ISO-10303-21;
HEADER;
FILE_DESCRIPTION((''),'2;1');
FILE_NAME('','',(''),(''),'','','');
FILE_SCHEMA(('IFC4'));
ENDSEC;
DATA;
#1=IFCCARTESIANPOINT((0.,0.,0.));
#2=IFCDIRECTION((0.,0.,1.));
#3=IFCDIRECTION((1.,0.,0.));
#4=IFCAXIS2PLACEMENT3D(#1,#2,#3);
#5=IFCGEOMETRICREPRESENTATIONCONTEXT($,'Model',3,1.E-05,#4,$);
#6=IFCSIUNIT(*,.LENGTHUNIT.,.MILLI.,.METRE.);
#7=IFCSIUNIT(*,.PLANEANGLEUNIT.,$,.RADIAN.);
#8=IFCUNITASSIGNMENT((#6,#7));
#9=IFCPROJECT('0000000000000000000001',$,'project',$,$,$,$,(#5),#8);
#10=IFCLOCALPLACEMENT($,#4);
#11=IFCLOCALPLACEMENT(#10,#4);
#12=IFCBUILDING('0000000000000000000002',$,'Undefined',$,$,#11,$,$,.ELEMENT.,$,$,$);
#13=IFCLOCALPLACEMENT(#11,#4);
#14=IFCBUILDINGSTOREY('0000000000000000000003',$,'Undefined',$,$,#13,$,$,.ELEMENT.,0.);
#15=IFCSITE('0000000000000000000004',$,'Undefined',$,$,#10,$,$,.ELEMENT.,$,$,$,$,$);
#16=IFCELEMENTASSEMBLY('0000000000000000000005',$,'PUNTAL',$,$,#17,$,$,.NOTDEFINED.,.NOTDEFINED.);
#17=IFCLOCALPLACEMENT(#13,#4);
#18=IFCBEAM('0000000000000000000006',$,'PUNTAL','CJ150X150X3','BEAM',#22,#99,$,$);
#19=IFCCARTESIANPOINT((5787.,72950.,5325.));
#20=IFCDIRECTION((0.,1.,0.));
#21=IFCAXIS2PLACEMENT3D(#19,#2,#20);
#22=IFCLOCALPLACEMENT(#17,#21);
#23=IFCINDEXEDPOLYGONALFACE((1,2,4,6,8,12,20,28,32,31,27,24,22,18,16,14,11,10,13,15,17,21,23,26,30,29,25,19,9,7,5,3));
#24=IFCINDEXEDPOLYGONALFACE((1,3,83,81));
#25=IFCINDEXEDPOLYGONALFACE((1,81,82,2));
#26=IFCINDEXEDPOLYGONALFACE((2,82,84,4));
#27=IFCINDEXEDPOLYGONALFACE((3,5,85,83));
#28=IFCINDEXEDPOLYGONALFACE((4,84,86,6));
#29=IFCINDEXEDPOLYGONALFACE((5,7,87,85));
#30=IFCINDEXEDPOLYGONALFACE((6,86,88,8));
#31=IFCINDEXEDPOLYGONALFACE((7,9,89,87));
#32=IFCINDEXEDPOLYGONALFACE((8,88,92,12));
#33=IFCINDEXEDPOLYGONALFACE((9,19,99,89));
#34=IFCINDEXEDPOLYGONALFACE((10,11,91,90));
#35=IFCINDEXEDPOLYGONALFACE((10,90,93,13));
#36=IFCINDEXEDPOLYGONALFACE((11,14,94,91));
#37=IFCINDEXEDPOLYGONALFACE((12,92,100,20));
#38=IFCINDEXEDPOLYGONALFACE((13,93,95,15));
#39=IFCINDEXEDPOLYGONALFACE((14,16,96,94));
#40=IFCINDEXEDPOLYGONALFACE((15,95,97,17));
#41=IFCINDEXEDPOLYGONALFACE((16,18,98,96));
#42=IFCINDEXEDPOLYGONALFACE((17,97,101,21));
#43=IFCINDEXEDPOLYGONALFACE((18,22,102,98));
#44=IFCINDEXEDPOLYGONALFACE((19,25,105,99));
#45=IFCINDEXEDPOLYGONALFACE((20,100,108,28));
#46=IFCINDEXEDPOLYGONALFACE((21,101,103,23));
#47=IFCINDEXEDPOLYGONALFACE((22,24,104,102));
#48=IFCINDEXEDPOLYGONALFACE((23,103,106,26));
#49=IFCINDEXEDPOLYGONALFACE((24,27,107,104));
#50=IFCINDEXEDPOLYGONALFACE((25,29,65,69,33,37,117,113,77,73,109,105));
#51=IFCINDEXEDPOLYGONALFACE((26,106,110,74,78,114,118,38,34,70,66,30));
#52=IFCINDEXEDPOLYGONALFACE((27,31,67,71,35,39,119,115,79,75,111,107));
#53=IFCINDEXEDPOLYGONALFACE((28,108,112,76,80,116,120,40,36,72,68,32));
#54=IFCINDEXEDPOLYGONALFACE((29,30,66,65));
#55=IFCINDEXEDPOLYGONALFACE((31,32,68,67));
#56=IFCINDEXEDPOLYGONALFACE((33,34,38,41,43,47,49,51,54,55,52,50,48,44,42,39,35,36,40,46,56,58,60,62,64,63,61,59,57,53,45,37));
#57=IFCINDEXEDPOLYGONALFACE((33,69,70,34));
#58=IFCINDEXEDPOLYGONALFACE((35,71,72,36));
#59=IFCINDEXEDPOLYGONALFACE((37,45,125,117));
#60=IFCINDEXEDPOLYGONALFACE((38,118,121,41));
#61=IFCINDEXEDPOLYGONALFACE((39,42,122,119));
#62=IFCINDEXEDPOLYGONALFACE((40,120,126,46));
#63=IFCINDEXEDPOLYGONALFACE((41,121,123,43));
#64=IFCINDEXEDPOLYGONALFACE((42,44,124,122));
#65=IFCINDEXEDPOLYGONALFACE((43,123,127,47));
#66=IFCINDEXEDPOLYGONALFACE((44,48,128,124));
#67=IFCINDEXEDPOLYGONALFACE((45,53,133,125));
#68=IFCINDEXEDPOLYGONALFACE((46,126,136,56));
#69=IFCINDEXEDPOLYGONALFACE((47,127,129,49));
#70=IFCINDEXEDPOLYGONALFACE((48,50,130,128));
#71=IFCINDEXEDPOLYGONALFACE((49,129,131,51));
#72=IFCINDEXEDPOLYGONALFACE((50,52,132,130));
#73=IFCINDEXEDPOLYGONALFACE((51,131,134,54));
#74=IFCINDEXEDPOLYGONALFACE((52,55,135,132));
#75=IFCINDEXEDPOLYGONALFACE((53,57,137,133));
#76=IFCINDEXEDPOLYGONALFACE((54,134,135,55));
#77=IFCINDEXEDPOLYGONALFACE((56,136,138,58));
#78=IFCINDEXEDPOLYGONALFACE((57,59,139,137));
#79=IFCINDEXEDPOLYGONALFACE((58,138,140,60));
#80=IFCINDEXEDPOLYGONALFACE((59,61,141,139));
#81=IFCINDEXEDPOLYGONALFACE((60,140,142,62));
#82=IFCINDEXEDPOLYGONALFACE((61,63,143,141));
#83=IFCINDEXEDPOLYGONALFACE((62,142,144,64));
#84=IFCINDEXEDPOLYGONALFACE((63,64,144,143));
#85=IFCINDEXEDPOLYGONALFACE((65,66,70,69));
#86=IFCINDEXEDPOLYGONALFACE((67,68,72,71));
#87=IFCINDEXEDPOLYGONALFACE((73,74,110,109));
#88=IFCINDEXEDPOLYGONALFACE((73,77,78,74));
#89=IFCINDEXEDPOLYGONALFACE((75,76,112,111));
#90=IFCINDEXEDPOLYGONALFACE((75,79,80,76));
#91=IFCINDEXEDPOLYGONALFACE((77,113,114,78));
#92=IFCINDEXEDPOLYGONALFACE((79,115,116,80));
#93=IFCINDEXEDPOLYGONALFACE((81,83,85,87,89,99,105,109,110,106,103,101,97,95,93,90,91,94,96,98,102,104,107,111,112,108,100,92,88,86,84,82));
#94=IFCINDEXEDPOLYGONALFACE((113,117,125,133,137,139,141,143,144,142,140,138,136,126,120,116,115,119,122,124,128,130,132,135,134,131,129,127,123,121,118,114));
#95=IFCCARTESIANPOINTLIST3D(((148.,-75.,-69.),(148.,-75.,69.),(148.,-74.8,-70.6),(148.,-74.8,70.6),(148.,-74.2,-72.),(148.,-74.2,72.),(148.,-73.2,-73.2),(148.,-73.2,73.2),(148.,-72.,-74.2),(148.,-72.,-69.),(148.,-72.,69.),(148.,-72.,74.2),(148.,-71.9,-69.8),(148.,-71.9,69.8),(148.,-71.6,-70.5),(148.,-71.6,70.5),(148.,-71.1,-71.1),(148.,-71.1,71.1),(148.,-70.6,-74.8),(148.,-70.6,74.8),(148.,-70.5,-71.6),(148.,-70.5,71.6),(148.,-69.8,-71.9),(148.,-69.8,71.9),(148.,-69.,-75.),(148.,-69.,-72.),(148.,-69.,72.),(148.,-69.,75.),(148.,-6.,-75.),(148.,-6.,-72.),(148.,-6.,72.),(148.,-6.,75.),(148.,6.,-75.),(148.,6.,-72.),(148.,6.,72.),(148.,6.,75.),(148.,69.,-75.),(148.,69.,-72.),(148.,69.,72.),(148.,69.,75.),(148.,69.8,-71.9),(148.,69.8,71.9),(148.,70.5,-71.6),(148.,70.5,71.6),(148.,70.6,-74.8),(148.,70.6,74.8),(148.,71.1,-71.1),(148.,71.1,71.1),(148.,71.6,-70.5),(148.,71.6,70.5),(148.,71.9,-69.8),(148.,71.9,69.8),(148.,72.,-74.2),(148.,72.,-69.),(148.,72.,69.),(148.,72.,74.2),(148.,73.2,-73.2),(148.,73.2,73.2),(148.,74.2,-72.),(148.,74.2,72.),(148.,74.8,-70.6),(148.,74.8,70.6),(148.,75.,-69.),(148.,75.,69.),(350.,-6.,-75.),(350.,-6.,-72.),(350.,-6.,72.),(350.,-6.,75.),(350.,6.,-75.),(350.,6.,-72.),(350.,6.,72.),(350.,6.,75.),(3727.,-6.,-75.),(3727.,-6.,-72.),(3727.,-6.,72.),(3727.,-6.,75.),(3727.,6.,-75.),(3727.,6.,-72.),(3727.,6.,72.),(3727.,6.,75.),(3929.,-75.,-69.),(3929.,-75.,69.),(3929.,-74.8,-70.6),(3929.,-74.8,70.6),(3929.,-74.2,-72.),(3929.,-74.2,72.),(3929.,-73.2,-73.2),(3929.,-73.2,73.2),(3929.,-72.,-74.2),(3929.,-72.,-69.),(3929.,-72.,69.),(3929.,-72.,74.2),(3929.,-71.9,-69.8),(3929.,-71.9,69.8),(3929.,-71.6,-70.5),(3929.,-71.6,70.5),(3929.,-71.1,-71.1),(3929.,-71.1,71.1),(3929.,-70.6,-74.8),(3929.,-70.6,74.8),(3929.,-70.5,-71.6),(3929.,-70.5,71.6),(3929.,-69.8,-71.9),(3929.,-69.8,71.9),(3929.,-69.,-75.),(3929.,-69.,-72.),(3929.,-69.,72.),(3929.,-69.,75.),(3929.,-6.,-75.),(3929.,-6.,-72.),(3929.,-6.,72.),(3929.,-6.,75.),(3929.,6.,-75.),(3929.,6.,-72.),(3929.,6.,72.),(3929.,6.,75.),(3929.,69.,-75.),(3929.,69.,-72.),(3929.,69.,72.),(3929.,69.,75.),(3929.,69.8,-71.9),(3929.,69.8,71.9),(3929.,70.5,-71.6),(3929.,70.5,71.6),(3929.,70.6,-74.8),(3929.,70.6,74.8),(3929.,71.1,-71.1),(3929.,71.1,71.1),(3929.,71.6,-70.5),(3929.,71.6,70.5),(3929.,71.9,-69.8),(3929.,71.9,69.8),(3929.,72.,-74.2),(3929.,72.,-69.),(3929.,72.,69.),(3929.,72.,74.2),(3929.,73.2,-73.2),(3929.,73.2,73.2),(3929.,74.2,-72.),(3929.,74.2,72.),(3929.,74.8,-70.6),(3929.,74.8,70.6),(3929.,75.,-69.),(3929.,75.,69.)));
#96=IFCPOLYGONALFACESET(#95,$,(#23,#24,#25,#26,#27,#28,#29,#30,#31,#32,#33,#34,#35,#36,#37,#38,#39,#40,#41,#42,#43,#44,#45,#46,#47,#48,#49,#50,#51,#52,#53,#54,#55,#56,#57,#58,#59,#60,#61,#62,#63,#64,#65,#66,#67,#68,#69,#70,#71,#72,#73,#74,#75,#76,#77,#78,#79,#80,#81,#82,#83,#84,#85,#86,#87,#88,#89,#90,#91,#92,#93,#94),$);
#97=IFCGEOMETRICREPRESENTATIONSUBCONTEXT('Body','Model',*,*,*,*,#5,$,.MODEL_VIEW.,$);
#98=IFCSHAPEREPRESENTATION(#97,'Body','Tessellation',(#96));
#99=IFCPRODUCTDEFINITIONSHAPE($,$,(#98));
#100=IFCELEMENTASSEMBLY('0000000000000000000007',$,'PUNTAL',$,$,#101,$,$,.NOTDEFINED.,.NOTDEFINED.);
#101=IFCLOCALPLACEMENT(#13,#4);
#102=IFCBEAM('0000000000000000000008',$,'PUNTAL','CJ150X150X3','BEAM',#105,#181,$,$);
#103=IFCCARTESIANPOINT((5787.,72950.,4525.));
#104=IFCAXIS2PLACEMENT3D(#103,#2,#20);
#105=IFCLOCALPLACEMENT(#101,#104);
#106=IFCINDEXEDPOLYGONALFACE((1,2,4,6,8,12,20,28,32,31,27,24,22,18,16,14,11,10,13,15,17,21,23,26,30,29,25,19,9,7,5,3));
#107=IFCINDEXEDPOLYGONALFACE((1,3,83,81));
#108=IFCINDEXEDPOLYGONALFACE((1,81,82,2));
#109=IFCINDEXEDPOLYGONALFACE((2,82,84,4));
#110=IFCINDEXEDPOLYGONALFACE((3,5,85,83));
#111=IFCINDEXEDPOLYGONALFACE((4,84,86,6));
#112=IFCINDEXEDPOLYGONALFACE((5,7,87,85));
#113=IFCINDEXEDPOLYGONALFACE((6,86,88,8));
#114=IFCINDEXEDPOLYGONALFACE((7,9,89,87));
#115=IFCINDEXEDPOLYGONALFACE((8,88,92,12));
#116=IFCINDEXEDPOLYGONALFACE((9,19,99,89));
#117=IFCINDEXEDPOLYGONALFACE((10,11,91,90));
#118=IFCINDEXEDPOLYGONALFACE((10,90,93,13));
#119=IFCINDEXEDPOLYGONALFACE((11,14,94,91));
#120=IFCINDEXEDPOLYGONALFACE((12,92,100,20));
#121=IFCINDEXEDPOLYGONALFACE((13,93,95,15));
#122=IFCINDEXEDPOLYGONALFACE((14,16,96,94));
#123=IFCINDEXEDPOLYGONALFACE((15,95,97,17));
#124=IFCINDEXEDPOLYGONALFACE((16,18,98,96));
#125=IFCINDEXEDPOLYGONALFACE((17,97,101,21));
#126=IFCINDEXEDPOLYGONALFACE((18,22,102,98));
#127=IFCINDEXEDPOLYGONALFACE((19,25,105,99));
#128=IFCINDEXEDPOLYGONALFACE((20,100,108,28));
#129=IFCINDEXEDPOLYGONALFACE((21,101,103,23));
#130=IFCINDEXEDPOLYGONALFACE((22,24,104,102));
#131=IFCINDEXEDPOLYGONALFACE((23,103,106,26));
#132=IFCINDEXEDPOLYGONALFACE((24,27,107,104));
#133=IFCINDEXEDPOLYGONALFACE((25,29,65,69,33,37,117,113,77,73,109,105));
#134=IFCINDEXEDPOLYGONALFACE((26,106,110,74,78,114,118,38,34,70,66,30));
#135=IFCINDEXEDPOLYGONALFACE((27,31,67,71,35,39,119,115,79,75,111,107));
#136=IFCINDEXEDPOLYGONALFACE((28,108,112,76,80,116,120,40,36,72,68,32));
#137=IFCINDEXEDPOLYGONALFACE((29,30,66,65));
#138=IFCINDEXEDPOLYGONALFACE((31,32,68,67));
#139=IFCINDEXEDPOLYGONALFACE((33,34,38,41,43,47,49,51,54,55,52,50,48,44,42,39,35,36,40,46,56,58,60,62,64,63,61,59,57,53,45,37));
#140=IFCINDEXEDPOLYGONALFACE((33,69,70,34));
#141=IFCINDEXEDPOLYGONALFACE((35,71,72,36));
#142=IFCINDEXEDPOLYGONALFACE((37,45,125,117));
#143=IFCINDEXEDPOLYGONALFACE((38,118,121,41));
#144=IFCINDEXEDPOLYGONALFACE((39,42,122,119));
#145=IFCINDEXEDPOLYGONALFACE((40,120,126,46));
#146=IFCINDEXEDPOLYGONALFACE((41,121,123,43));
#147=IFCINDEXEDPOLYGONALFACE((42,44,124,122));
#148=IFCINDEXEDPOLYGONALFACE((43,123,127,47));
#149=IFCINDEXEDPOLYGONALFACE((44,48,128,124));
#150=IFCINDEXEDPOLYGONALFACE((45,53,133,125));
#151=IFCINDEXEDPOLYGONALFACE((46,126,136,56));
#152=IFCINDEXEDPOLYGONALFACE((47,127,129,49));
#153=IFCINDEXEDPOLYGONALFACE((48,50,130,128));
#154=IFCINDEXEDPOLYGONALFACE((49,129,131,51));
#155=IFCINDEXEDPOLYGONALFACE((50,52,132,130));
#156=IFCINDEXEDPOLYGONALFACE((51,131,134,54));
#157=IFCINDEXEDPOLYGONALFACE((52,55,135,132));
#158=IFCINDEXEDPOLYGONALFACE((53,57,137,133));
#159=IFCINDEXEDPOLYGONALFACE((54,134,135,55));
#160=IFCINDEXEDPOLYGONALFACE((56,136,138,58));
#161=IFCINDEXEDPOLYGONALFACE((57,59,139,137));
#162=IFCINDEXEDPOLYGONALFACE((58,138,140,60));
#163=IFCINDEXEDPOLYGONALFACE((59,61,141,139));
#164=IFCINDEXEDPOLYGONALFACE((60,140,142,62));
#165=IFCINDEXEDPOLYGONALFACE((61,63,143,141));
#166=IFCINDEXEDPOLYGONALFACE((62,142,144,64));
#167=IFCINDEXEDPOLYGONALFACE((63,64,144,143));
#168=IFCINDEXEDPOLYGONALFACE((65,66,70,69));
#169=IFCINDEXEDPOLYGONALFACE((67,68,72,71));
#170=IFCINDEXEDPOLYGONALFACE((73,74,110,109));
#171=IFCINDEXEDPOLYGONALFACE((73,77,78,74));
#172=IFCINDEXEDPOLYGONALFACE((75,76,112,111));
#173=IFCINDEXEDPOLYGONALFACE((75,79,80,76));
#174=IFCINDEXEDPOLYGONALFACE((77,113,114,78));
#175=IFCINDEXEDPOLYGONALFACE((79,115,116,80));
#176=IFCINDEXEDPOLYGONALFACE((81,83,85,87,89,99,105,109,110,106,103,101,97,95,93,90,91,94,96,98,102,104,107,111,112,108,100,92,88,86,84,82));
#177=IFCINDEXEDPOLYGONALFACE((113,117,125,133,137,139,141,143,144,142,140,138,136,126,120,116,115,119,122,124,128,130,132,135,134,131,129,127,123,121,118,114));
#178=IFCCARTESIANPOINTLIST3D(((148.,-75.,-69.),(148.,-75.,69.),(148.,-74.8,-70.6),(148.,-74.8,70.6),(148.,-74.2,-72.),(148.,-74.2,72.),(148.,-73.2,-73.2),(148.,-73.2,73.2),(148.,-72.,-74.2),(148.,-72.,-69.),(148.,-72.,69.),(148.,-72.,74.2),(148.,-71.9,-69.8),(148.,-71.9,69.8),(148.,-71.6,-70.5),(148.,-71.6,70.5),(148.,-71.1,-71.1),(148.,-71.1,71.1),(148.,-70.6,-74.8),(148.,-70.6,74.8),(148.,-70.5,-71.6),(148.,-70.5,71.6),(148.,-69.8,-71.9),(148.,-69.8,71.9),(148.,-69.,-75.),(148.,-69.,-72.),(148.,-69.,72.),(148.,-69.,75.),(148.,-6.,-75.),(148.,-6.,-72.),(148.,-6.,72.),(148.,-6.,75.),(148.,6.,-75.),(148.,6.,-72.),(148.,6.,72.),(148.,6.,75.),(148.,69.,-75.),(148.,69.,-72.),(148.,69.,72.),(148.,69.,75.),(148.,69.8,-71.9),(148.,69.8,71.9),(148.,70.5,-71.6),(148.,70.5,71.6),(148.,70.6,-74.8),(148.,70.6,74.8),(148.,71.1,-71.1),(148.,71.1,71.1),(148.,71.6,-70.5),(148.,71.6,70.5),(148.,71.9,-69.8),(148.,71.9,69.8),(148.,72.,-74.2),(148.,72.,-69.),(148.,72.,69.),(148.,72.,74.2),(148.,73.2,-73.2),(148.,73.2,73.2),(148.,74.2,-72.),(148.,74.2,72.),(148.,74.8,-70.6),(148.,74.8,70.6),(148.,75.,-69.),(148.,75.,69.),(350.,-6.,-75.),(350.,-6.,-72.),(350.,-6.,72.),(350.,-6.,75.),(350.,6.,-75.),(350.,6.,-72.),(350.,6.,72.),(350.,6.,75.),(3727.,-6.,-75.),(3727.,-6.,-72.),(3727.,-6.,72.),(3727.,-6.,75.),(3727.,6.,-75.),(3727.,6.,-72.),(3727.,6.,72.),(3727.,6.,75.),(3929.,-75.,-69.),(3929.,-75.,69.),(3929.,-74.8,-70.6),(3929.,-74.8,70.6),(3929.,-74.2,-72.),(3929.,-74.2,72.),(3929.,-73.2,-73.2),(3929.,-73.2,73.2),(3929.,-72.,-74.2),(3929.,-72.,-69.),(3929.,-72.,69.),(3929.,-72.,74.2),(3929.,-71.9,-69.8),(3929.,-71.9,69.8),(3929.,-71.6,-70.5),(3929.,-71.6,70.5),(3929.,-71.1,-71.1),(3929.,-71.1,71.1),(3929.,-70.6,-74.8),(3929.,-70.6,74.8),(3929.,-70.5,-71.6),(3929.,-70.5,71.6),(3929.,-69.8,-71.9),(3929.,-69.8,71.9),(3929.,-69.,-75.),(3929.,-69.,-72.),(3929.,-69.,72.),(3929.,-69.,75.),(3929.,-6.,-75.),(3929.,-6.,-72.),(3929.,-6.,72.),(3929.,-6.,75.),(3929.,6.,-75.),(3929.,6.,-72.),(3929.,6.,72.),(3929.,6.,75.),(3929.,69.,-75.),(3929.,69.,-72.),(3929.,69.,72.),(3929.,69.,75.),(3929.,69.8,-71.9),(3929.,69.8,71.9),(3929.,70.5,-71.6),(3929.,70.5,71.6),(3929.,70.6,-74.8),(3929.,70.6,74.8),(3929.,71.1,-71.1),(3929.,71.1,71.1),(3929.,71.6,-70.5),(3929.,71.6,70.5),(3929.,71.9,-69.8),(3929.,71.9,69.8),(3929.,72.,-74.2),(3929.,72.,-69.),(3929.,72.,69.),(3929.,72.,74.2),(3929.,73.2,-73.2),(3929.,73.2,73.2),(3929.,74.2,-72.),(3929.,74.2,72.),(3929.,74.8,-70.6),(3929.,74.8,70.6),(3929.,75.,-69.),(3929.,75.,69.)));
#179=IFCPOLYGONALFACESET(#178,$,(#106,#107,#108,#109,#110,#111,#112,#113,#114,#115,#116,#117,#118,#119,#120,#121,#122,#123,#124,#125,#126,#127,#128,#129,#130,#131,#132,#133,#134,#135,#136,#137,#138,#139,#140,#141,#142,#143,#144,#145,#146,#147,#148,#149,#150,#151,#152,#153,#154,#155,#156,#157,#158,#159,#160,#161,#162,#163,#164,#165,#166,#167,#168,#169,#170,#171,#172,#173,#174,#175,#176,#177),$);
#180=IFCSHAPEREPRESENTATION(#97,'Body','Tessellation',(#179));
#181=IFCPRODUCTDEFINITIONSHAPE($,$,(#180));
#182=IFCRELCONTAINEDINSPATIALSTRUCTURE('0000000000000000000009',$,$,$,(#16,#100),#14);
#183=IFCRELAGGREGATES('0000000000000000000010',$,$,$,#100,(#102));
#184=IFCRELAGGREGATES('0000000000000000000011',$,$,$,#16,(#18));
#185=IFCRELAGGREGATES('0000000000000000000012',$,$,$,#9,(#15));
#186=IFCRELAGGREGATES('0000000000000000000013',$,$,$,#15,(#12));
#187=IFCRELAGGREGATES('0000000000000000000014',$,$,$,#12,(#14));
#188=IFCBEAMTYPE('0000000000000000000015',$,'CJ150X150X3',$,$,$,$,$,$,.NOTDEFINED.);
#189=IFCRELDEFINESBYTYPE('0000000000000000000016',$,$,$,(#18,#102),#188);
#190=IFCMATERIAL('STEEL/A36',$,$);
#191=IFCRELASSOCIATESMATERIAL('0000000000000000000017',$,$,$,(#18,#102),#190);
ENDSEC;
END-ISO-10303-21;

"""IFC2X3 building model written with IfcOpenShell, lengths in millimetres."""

from ifc_helpers import new_model, si_unit, frame, origin_with_axes, origin_2d_with_axis, place, context, subcontext, project, spatial, rectangle, hollow_rectangle, extrude, boolean, halfspace, material, type_object, element, aggregate, save


model = new_model("IFC2X3")

# Units and contexts
model_context = context("Model", 3, precision=1e-05, world=origin_with_axes())
body_context = subcontext(model_context, "Body", "Model", "MODEL_VIEW")
ifc_project = project(units=[si_unit("LENGTHUNIT", "METRE", prefix="MILLI"), si_unit("PLANEANGLEUNIT", "RADIAN")], contexts=[model_context])

# Site, building, storey
site_placement = place(None, origin_with_axes())
site = spatial("IfcSite", under=ifc_project, at=site_placement, Name="Undefined", CompositionType="ELEMENT")
building_placement = place(site_placement, origin_with_axes())
building = spatial("IfcBuilding", under=site, at=building_placement, Name="Undefined", CompositionType="ELEMENT")
storey_placement = place(building_placement, origin_with_axes())
storey = spatial("IfcBuildingStorey", under=building, at=storey_placement, Name="Undefined", CompositionType="ELEMENT", Elevation=0.0)

# Element assemblies, beams
ifc_material_1 = material(Name="STEEL/A36")
assembly_1_placement = place(storey_placement, origin_with_axes())
assembly_1 = element("IfcElementAssembly", 1, at=assembly_1_placement, inside=storey, Name="PUNTAL", AssemblyPlace="NOTDEFINED", PredefinedType="NOTDEFINED")
beam_type_1 = type_object("IfcBeamType", Name="CJ150X150X3", PredefinedType="NOTDEFINED")
beam_1_placement = place(assembly_1_placement, frame((5787.0, 72950.0, 5325.0), z_axis=(0.0, 0.0, 1.0), x_axis=(0.0, 1.0, 0.0)))
beam_1 = element("IfcBeam", 2, at=beam_1_placement, type_object=beam_type_1, material=ifc_material_1, Name="PUNTAL", Description="CJ150X150X3", ObjectType="BEAM", context=body_context, shape_type="CSG", body=[
    boolean("DIFFERENCE", boolean("DIFFERENCE", boolean("DIFFERENCE", boolean("DIFFERENCE", extrude(hollow_rectangle(XDim=150.0, YDim=150.0, WallThickness=3.0, InnerFilletRadius=3.0, OuterFilletRadius=6.0, at=origin_2d_with_axis()), frame((4077.0, 0.0, 0.0), z_axis=(-1.0, 0.0, 0.0), x_axis=(0.0, -1.0, 0.0)), (0.0, 0.0, 1.0), 4077.0), extrude(rectangle(XDim=12.0, YDim=154.0, at=origin_2d_with_axis()), frame((3727.0, 0.0, 0.0), z_axis=(1.0, 0.0, 0.0), x_axis=(0.0, -1.0, 0.0)), (0.0, 0.0, 1.0), 204.0)), extrude(rectangle(XDim=12.0, YDim=154.0, at=origin_2d_with_axis()), frame((350.0, 0.0, 0.0), z_axis=(-1.0, 0.0, 0.0), x_axis=(0.0, 1.0, 0.0)), (0.0, 0.0, 1.0), 204.0)), halfspace(frame((3929.0, 15.0, 0.0), z_axis=(-1.0, 0.0, 0.0), x_axis=(0.0, -1.0, 0.0)), True)), halfspace(frame((148.0, 15.0, 0.0), z_axis=(1.0, 0.0, 0.0), x_axis=(0.0, 0.0, -1.0)), True)),
])
assembly_2_placement = place(storey_placement, origin_with_axes())
assembly_2 = element("IfcElementAssembly", 3, at=assembly_2_placement, inside=storey, Name="PUNTAL", AssemblyPlace="NOTDEFINED", PredefinedType="NOTDEFINED")
beam_2_placement = place(assembly_2_placement, frame((5787.0, 72950.0, 4525.0), z_axis=(0.0, 0.0, 1.0), x_axis=(0.0, 1.0, 0.0)))
beam_2 = element("IfcBeam", 4, at=beam_2_placement, type_object=beam_type_1, material=ifc_material_1, Name="PUNTAL", Description="CJ150X150X3", ObjectType="BEAM", context=body_context, shape_type="CSG", body=[
    boolean("DIFFERENCE", boolean("DIFFERENCE", boolean("DIFFERENCE", boolean("DIFFERENCE", extrude(hollow_rectangle(XDim=150.0, YDim=150.0, WallThickness=3.0, InnerFilletRadius=3.0, OuterFilletRadius=6.0, at=origin_2d_with_axis()), frame((4077.0, 0.0, 0.0), z_axis=(-1.0, 0.0, 0.0), x_axis=(0.0, -1.0, 0.0)), (0.0, 0.0, 1.0), 4077.0), extrude(rectangle(XDim=12.0, YDim=154.0, at=origin_2d_with_axis()), frame((3727.0, 0.0, 0.0), z_axis=(1.0, 0.0, 0.0), x_axis=(0.0, 1.0, 0.0)), (0.0, 0.0, 1.0), 215.0)), extrude(rectangle(XDim=12.0, YDim=154.0, at=origin_2d_with_axis()), frame((350.0, 0.0, 0.0), z_axis=(-1.0, 0.0, 0.0), x_axis=(0.0, -1.0, 0.0)), (0.0, 0.0, 1.0), 215.0)), halfspace(frame((3929.0, -15.0, 0.0), z_axis=(-1.0, 0.0, 0.0), x_axis=(0.0, 1.0, 0.0)), True)), halfspace(frame((148.0, -15.0, 0.0), z_axis=(1.0, 0.0, 0.0), x_axis=(0.0, 0.0, 1.0)), True)),
])

aggregate(assembly_2, [beam_2])
aggregate(assembly_1, [beam_1])

save(model, "model.ifc")
